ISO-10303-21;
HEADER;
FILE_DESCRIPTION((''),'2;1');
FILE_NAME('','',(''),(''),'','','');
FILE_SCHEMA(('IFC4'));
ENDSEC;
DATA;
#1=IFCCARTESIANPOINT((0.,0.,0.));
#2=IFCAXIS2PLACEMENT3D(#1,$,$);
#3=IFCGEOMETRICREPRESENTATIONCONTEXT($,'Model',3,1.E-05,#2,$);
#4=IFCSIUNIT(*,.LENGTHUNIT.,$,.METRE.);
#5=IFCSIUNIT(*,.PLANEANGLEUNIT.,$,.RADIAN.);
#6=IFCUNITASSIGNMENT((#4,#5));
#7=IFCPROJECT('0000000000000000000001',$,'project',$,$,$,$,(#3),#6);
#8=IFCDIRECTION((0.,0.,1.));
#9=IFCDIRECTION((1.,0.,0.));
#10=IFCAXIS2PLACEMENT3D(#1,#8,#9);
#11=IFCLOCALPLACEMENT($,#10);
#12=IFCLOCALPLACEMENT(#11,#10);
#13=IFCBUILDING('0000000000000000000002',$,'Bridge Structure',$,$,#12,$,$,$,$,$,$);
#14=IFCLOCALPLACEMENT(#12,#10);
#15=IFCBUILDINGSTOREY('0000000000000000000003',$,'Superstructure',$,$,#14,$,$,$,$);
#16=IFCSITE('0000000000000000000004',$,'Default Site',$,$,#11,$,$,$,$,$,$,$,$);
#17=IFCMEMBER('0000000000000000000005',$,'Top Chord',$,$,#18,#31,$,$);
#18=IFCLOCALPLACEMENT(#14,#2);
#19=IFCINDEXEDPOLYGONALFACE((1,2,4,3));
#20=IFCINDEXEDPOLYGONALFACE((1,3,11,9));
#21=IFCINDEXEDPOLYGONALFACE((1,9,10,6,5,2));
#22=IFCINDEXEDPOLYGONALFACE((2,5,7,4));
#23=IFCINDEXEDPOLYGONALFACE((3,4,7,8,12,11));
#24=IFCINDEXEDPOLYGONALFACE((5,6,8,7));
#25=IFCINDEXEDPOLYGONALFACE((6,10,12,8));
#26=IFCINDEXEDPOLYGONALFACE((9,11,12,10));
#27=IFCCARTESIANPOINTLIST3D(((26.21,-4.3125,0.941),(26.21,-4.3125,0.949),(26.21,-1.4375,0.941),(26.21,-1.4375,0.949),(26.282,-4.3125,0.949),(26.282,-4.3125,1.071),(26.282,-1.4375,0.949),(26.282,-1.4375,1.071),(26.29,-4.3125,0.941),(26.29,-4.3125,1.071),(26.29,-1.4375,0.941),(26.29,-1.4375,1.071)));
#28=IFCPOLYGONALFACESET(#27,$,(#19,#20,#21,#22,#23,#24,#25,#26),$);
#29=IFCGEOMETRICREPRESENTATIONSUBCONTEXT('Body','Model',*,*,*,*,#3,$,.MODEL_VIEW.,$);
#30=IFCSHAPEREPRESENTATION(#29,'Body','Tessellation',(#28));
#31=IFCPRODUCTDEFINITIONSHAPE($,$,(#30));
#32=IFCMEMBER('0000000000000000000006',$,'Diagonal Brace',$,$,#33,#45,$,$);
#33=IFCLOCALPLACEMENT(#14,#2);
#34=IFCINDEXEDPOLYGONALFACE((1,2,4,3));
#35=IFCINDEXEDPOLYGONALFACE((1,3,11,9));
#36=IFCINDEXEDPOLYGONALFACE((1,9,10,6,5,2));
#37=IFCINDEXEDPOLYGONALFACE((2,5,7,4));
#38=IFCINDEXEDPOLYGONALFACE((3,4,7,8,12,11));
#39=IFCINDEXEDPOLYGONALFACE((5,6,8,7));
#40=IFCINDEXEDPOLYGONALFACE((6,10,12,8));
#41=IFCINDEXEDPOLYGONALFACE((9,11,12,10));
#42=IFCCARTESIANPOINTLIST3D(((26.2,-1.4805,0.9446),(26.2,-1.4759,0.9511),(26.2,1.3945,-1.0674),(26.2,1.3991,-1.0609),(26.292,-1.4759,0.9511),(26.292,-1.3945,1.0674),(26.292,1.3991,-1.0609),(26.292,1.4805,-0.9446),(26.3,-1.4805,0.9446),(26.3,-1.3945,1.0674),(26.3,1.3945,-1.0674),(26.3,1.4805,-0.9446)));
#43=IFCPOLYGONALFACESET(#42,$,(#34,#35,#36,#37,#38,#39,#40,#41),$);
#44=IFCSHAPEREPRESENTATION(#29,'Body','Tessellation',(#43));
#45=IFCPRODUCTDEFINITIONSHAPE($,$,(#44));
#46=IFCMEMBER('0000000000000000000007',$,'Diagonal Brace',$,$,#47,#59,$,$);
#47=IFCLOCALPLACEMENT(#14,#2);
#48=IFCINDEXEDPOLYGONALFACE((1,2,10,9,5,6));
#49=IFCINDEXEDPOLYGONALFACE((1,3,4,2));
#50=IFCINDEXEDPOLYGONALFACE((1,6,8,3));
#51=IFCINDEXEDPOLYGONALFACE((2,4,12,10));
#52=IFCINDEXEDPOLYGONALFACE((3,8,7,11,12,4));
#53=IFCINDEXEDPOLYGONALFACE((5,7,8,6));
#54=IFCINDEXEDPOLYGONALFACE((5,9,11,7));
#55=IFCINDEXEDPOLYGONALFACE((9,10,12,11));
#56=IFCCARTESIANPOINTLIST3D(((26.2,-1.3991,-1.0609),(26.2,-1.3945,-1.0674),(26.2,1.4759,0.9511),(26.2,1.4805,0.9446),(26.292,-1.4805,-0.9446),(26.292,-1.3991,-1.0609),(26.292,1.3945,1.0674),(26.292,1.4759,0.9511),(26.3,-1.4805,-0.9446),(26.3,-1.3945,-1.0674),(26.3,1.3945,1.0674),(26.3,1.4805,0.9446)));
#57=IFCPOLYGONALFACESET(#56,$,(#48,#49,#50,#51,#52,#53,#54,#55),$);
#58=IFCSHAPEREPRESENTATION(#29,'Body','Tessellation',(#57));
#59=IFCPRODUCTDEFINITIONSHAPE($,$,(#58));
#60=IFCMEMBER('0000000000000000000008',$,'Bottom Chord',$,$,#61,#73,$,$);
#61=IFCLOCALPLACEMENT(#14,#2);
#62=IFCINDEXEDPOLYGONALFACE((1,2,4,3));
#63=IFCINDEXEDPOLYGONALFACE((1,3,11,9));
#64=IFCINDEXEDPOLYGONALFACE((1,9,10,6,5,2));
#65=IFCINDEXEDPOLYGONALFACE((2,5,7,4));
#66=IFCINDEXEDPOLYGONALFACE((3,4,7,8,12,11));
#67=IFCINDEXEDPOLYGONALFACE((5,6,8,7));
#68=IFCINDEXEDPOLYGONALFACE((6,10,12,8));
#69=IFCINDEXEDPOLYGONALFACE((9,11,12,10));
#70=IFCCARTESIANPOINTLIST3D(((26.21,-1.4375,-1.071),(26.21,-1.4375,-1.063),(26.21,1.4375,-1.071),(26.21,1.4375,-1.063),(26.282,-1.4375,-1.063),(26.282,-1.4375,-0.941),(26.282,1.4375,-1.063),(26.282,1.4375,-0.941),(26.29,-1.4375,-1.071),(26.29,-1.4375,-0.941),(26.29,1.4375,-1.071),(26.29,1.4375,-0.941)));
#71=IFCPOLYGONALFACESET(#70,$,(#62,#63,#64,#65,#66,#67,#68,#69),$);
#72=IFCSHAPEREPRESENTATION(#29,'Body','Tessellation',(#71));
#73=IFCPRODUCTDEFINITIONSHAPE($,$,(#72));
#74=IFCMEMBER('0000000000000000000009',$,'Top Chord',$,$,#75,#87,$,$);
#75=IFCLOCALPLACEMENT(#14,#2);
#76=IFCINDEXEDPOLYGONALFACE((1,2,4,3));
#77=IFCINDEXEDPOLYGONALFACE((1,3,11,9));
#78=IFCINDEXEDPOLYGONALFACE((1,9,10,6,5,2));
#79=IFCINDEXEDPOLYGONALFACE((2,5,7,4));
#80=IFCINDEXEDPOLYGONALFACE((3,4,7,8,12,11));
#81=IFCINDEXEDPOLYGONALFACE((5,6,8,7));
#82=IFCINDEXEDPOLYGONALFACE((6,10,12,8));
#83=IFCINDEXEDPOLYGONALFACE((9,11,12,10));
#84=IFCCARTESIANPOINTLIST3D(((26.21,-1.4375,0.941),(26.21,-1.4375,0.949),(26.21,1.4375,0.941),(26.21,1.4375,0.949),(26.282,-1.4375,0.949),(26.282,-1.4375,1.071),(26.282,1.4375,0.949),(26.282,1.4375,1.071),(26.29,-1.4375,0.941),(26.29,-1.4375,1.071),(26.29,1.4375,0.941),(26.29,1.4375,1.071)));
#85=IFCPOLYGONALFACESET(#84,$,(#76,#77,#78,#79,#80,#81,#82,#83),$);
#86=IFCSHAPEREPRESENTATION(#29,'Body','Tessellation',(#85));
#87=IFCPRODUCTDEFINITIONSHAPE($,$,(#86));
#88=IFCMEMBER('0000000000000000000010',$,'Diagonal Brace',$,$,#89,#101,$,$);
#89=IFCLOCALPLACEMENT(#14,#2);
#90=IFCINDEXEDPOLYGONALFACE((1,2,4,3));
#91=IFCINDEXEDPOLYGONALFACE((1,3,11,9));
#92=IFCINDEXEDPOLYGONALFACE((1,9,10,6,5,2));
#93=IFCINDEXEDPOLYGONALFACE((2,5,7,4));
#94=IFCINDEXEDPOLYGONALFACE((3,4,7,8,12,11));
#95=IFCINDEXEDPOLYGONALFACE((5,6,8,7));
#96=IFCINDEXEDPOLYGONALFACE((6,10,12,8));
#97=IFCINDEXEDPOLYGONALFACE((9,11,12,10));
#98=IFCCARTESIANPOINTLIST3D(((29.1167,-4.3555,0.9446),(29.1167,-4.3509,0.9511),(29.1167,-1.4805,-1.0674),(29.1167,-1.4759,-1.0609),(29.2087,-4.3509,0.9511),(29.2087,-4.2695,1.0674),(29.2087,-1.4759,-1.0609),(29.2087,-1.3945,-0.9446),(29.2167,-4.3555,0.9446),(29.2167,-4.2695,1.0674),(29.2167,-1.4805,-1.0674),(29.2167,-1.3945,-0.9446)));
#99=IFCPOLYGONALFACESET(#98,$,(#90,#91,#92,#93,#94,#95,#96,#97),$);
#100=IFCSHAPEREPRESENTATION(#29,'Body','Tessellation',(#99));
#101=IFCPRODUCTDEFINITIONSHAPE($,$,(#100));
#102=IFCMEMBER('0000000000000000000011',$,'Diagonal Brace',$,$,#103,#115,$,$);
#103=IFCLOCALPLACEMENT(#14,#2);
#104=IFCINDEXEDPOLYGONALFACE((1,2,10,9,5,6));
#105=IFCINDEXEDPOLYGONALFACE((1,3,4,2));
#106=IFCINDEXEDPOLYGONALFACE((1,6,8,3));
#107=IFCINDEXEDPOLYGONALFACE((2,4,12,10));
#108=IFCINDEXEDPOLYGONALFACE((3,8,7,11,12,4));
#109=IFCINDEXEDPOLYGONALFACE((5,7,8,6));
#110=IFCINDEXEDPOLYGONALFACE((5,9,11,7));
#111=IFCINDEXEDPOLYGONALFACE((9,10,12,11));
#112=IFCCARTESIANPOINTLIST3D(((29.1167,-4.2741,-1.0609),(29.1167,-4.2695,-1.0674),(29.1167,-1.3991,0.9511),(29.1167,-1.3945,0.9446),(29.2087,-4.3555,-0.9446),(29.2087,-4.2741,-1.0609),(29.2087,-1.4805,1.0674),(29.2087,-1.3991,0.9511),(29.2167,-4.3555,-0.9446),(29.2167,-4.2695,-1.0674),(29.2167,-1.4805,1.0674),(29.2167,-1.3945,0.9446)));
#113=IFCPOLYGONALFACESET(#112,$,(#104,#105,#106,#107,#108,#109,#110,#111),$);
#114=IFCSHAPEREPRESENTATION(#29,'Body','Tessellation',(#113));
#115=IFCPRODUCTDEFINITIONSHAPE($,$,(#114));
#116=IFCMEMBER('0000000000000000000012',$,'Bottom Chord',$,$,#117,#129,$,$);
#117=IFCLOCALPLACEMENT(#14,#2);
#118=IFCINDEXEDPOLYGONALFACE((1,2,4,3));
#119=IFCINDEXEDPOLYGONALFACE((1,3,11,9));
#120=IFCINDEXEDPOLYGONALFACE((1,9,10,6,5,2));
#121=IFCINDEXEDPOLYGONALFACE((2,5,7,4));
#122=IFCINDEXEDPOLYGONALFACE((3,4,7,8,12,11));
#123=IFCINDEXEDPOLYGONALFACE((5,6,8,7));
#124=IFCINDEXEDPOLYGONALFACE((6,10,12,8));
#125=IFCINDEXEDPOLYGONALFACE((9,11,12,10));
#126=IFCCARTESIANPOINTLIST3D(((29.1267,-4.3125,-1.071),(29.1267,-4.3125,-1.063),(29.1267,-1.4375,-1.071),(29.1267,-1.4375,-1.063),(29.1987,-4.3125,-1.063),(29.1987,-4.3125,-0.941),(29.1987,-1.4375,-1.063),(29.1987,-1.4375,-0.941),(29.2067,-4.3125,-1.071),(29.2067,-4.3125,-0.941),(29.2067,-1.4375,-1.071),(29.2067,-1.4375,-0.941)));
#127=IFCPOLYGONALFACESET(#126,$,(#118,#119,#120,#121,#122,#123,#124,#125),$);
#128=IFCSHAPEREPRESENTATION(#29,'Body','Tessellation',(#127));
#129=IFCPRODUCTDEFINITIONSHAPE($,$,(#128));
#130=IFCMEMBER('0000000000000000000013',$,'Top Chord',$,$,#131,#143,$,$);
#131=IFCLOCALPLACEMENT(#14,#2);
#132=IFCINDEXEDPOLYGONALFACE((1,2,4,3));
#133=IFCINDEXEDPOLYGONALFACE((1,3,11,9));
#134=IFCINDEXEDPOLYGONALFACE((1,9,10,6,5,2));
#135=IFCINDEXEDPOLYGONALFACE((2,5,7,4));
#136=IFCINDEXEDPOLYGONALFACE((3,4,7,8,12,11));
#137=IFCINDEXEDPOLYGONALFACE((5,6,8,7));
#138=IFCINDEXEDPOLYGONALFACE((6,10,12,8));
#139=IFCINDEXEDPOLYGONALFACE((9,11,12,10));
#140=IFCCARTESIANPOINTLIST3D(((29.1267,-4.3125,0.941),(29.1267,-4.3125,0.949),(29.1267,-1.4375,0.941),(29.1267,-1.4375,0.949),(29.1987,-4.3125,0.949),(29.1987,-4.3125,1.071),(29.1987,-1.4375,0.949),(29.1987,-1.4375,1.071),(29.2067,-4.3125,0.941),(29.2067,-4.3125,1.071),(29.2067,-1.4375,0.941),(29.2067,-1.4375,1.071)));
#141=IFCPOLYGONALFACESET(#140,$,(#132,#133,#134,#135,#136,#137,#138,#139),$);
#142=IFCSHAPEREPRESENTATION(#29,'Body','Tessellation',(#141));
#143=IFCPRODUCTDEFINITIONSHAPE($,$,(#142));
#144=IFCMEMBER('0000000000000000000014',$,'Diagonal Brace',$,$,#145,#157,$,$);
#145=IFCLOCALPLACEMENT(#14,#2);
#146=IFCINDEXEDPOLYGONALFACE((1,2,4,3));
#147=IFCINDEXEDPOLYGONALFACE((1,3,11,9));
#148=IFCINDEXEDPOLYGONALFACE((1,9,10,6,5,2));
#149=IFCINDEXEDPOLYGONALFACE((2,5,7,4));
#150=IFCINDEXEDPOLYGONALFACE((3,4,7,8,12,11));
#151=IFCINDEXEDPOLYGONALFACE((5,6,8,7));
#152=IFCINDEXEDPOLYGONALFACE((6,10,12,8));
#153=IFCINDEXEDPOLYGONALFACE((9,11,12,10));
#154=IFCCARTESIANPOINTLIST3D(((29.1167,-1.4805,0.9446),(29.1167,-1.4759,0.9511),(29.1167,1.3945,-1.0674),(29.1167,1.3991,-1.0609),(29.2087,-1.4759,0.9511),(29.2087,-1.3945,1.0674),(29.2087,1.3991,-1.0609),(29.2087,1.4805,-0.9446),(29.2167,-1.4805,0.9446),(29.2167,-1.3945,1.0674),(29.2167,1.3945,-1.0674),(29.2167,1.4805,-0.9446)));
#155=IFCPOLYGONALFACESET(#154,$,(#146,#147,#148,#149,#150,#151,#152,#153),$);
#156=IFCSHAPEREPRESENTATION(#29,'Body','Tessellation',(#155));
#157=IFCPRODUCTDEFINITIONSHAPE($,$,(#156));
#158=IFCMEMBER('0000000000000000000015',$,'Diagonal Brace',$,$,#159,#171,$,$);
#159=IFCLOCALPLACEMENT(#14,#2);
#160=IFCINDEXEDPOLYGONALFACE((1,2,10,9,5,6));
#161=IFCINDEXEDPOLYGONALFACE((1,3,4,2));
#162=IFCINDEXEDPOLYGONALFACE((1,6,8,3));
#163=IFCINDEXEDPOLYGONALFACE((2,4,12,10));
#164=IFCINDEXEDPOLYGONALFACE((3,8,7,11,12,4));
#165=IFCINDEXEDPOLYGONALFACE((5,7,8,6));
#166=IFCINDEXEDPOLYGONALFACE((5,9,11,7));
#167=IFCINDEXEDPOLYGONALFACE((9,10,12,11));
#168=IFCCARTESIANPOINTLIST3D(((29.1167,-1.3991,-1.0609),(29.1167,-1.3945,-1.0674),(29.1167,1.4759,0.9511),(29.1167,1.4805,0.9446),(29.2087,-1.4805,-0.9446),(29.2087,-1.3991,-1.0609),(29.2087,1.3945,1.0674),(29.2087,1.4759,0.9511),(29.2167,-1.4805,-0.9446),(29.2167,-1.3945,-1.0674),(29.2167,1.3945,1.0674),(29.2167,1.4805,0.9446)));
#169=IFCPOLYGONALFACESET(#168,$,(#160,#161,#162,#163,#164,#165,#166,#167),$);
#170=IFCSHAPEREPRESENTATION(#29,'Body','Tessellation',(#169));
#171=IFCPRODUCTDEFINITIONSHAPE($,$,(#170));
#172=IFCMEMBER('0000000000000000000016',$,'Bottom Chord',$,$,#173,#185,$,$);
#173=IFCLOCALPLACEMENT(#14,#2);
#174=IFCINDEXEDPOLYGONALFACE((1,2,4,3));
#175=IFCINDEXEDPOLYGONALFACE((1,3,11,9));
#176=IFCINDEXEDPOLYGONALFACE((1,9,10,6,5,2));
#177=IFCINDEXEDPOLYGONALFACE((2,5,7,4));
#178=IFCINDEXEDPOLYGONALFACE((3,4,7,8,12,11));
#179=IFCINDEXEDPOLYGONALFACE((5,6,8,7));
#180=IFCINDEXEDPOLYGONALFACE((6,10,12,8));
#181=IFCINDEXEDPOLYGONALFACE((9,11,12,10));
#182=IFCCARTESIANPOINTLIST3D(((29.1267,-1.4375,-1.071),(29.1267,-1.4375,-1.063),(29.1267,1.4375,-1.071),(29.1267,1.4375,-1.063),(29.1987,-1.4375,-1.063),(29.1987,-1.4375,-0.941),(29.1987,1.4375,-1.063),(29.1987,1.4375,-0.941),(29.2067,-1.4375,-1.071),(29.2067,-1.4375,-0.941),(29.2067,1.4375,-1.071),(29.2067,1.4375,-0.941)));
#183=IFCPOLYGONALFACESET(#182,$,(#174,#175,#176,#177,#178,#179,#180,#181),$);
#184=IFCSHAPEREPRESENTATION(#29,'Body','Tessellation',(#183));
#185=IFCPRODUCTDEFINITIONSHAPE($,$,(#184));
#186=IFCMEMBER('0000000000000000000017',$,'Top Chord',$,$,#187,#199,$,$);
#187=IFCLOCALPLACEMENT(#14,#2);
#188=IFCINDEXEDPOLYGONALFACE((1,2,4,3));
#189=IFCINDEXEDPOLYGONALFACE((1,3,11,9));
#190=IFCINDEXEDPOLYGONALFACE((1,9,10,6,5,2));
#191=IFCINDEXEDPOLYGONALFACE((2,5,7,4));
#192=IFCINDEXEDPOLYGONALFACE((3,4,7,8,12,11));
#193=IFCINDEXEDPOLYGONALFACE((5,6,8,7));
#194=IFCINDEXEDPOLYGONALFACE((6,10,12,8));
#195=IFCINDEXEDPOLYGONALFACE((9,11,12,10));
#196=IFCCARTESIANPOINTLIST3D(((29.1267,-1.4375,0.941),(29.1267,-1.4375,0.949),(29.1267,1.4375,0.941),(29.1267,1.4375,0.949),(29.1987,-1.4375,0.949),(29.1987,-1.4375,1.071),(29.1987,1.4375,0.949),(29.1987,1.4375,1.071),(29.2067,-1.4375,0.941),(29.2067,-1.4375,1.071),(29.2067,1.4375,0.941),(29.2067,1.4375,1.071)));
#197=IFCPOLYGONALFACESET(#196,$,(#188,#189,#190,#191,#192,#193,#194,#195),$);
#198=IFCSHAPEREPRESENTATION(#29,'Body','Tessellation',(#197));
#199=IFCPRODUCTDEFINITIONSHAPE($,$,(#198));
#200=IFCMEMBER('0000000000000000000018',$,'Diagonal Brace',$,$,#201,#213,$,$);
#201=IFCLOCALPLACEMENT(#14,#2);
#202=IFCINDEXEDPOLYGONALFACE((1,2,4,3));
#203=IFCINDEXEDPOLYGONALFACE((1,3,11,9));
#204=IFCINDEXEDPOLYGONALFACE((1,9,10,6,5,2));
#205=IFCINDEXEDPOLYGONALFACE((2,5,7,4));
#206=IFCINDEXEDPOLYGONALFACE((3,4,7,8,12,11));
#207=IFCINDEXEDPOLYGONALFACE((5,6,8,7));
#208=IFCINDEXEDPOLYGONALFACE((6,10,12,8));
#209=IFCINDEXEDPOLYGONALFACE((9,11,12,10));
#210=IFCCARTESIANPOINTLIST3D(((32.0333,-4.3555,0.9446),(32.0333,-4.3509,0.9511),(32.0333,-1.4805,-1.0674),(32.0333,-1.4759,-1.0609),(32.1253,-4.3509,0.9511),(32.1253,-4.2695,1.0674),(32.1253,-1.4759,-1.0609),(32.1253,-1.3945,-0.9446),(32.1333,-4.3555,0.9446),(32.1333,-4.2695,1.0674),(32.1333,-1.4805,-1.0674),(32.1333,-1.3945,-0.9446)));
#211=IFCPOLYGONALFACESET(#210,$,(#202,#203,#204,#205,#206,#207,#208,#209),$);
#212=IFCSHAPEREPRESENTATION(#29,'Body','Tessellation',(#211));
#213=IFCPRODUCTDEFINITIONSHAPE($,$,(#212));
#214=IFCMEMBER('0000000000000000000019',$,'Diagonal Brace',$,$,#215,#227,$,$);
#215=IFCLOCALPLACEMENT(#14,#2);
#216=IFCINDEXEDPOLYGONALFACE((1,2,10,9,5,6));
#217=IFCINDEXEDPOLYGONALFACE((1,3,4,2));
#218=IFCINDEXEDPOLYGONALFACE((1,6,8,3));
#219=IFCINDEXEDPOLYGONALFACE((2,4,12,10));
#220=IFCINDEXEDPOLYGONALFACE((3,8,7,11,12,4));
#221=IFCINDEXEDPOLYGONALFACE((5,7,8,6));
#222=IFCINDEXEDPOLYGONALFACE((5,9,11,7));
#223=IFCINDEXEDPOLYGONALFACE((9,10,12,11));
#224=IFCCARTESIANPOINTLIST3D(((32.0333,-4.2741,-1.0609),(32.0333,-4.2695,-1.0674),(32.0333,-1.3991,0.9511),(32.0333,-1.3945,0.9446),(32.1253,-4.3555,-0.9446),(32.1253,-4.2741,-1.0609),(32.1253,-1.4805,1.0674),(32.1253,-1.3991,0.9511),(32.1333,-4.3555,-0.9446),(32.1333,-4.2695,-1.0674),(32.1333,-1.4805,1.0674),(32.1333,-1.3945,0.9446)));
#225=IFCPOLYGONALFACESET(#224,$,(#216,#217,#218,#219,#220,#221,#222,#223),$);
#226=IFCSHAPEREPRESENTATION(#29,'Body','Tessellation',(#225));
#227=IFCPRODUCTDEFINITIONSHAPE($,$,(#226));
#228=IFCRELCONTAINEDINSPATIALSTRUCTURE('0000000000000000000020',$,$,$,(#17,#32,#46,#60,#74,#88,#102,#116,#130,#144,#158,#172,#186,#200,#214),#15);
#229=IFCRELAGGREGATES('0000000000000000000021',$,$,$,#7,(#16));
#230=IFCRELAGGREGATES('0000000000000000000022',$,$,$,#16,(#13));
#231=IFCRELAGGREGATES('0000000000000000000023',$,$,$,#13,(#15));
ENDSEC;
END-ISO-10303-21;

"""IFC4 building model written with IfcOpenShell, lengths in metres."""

from ifc_helpers import new_model, si_unit, frame, origin, origin_with_axes, origin_2d_with_axis, place, context, subcontext, project, spatial, l_section, extrude, element, save


model = new_model("IFC4")

# Units and contexts
model_context = context("Model", 3, precision=1e-05, world=origin())
body_context = subcontext(model_context, "Body", "Model", "MODEL_VIEW")
ifc_project = project(units=[si_unit("LENGTHUNIT", "METRE"), si_unit("PLANEANGLEUNIT", "RADIAN")], contexts=[model_context])

# Site, building, storey
site_placement = place(None, origin_with_axes())
site = spatial("IfcSite", under=ifc_project, at=site_placement, Name="Default Site")
building_placement = place(site_placement, origin_with_axes())
building = spatial("IfcBuilding", under=site, at=building_placement, Name="Bridge Structure")
storey_placement = place(building_placement, origin_with_axes())
storey = spatial("IfcBuildingStorey", under=building, at=storey_placement, Name="Superstructure")

# Members
member_1_placement = place(storey_placement, frame((26.25, -4.3125, 1.006), z_axis=(0.0, 1.0, 0.0), x_axis=(-1.0, 0.0, 0.0)))
element("IfcMember", 1, at=member_1_placement, inside=storey, Name="Top Chord", context=body_context, shape_type="SweptSolid", body=[
    extrude(l_section(Depth=0.13, Width=0.08, Thickness=0.008, at=origin_2d_with_axis()), origin_with_axes(), (0.0, 0.0, 1.0), 2.875),
])
for number, where, z_axis, x_axis, name in (
    (2, (26.25, -1.4375, 1.006), (0.0, 0.819299, -0.573367), (-1.0, 0.0, 0.0), "Diagonal Brace"),
    (3, (26.25, -1.4375, -1.006), (0.0, 0.819299, 0.573367), (-1.0, 0.0, 0.0), "Diagonal Brace"),
):
    element("IfcMember", number, at=place(storey_placement, frame(where, z_axis=z_axis, x_axis=x_axis)), inside=storey, Name=name, context=body_context, shape_type="SweptSolid", body=[
        extrude(l_section(Depth=0.15, Width=0.1, Thickness=0.008, at=origin_2d_with_axis()), origin_with_axes(), (0.0, 0.0, 1.0), 3.5091),
    ])
for number, where, z_axis, x_axis, name in (
    (4, (26.25, -1.4375, -1.006), (0.0, 1.0, 0.0), (-1.0, 0.0, 0.0), "Bottom Chord"),
    (5, (26.25, -1.4375, 1.006), (0.0, 1.0, 0.0), (-1.0, 0.0, 0.0), "Top Chord"),
):
    element("IfcMember", number, at=place(storey_placement, frame(where, z_axis=z_axis, x_axis=x_axis)), inside=storey, Name=name, context=body_context, shape_type="SweptSolid", body=[
        extrude(l_section(Depth=0.13, Width=0.08, Thickness=0.008, at=origin_2d_with_axis()), origin_with_axes(), (0.0, 0.0, 1.0), 2.875),
    ])
for number, where, z_axis, x_axis, name in (
    (6, (29.1667, -4.3125, 1.006), (0.0, 0.819299, -0.573367), (-1.0, 0.0, 0.0), "Diagonal Brace"),
    (7, (29.1667, -4.3125, -1.006), (0.0, 0.819299, 0.573367), (-1.0, 0.0, 0.0), "Diagonal Brace"),
):
    element("IfcMember", number, at=place(storey_placement, frame(where, z_axis=z_axis, x_axis=x_axis)), inside=storey, Name=name, context=body_context, shape_type="SweptSolid", body=[
        extrude(l_section(Depth=0.15, Width=0.1, Thickness=0.008, at=origin_2d_with_axis()), origin_with_axes(), (0.0, 0.0, 1.0), 3.5091),
    ])
for number, where, z_axis, x_axis, name in (
    (8, (29.1667, -4.3125, -1.006), (0.0, 1.0, 0.0), (-1.0, 0.0, 0.0), "Bottom Chord"),
    (9, (29.1667, -4.3125, 1.006), (0.0, 1.0, 0.0), (-1.0, 0.0, 0.0), "Top Chord"),
):
    element("IfcMember", number, at=place(storey_placement, frame(where, z_axis=z_axis, x_axis=x_axis)), inside=storey, Name=name, context=body_context, shape_type="SweptSolid", body=[
        extrude(l_section(Depth=0.13, Width=0.08, Thickness=0.008, at=origin_2d_with_axis()), origin_with_axes(), (0.0, 0.0, 1.0), 2.875),
    ])
for number, where, z_axis, x_axis, name in (
    (10, (29.1667, -1.4375, 1.006), (0.0, 0.819299, -0.573367), (-1.0, 0.0, 0.0), "Diagonal Brace"),
    (11, (29.1667, -1.4375, -1.006), (0.0, 0.819299, 0.573367), (-1.0, 0.0, 0.0), "Diagonal Brace"),
):
    element("IfcMember", number, at=place(storey_placement, frame(where, z_axis=z_axis, x_axis=x_axis)), inside=storey, Name=name, context=body_context, shape_type="SweptSolid", body=[
        extrude(l_section(Depth=0.15, Width=0.1, Thickness=0.008, at=origin_2d_with_axis()), origin_with_axes(), (0.0, 0.0, 1.0), 3.5091),
    ])
for number, where, z_axis, x_axis, name in (
    (12, (29.1667, -1.4375, -1.006), (0.0, 1.0, 0.0), (-1.0, 0.0, 0.0), "Bottom Chord"),
    (13, (29.1667, -1.4375, 1.006), (0.0, 1.0, 0.0), (-1.0, 0.0, 0.0), "Top Chord"),
):
    element("IfcMember", number, at=place(storey_placement, frame(where, z_axis=z_axis, x_axis=x_axis)), inside=storey, Name=name, context=body_context, shape_type="SweptSolid", body=[
        extrude(l_section(Depth=0.13, Width=0.08, Thickness=0.008, at=origin_2d_with_axis()), origin_with_axes(), (0.0, 0.0, 1.0), 2.875),
    ])
for number, where, z_axis, x_axis, name in (
    (14, (32.0833, -4.3125, 1.006), (0.0, 0.819299, -0.573367), (-1.0, 0.0, 0.0), "Diagonal Brace"),
    (15, (32.0833, -4.3125, -1.006), (0.0, 0.819299, 0.573367), (-1.0, 0.0, 0.0), "Diagonal Brace"),
):
    element("IfcMember", number, at=place(storey_placement, frame(where, z_axis=z_axis, x_axis=x_axis)), inside=storey, Name=name, context=body_context, shape_type="SweptSolid", body=[
        extrude(l_section(Depth=0.15, Width=0.1, Thickness=0.008, at=origin_2d_with_axis()), origin_with_axes(), (0.0, 0.0, 1.0), 3.5091),
    ])

save(model, "model.ifc")
